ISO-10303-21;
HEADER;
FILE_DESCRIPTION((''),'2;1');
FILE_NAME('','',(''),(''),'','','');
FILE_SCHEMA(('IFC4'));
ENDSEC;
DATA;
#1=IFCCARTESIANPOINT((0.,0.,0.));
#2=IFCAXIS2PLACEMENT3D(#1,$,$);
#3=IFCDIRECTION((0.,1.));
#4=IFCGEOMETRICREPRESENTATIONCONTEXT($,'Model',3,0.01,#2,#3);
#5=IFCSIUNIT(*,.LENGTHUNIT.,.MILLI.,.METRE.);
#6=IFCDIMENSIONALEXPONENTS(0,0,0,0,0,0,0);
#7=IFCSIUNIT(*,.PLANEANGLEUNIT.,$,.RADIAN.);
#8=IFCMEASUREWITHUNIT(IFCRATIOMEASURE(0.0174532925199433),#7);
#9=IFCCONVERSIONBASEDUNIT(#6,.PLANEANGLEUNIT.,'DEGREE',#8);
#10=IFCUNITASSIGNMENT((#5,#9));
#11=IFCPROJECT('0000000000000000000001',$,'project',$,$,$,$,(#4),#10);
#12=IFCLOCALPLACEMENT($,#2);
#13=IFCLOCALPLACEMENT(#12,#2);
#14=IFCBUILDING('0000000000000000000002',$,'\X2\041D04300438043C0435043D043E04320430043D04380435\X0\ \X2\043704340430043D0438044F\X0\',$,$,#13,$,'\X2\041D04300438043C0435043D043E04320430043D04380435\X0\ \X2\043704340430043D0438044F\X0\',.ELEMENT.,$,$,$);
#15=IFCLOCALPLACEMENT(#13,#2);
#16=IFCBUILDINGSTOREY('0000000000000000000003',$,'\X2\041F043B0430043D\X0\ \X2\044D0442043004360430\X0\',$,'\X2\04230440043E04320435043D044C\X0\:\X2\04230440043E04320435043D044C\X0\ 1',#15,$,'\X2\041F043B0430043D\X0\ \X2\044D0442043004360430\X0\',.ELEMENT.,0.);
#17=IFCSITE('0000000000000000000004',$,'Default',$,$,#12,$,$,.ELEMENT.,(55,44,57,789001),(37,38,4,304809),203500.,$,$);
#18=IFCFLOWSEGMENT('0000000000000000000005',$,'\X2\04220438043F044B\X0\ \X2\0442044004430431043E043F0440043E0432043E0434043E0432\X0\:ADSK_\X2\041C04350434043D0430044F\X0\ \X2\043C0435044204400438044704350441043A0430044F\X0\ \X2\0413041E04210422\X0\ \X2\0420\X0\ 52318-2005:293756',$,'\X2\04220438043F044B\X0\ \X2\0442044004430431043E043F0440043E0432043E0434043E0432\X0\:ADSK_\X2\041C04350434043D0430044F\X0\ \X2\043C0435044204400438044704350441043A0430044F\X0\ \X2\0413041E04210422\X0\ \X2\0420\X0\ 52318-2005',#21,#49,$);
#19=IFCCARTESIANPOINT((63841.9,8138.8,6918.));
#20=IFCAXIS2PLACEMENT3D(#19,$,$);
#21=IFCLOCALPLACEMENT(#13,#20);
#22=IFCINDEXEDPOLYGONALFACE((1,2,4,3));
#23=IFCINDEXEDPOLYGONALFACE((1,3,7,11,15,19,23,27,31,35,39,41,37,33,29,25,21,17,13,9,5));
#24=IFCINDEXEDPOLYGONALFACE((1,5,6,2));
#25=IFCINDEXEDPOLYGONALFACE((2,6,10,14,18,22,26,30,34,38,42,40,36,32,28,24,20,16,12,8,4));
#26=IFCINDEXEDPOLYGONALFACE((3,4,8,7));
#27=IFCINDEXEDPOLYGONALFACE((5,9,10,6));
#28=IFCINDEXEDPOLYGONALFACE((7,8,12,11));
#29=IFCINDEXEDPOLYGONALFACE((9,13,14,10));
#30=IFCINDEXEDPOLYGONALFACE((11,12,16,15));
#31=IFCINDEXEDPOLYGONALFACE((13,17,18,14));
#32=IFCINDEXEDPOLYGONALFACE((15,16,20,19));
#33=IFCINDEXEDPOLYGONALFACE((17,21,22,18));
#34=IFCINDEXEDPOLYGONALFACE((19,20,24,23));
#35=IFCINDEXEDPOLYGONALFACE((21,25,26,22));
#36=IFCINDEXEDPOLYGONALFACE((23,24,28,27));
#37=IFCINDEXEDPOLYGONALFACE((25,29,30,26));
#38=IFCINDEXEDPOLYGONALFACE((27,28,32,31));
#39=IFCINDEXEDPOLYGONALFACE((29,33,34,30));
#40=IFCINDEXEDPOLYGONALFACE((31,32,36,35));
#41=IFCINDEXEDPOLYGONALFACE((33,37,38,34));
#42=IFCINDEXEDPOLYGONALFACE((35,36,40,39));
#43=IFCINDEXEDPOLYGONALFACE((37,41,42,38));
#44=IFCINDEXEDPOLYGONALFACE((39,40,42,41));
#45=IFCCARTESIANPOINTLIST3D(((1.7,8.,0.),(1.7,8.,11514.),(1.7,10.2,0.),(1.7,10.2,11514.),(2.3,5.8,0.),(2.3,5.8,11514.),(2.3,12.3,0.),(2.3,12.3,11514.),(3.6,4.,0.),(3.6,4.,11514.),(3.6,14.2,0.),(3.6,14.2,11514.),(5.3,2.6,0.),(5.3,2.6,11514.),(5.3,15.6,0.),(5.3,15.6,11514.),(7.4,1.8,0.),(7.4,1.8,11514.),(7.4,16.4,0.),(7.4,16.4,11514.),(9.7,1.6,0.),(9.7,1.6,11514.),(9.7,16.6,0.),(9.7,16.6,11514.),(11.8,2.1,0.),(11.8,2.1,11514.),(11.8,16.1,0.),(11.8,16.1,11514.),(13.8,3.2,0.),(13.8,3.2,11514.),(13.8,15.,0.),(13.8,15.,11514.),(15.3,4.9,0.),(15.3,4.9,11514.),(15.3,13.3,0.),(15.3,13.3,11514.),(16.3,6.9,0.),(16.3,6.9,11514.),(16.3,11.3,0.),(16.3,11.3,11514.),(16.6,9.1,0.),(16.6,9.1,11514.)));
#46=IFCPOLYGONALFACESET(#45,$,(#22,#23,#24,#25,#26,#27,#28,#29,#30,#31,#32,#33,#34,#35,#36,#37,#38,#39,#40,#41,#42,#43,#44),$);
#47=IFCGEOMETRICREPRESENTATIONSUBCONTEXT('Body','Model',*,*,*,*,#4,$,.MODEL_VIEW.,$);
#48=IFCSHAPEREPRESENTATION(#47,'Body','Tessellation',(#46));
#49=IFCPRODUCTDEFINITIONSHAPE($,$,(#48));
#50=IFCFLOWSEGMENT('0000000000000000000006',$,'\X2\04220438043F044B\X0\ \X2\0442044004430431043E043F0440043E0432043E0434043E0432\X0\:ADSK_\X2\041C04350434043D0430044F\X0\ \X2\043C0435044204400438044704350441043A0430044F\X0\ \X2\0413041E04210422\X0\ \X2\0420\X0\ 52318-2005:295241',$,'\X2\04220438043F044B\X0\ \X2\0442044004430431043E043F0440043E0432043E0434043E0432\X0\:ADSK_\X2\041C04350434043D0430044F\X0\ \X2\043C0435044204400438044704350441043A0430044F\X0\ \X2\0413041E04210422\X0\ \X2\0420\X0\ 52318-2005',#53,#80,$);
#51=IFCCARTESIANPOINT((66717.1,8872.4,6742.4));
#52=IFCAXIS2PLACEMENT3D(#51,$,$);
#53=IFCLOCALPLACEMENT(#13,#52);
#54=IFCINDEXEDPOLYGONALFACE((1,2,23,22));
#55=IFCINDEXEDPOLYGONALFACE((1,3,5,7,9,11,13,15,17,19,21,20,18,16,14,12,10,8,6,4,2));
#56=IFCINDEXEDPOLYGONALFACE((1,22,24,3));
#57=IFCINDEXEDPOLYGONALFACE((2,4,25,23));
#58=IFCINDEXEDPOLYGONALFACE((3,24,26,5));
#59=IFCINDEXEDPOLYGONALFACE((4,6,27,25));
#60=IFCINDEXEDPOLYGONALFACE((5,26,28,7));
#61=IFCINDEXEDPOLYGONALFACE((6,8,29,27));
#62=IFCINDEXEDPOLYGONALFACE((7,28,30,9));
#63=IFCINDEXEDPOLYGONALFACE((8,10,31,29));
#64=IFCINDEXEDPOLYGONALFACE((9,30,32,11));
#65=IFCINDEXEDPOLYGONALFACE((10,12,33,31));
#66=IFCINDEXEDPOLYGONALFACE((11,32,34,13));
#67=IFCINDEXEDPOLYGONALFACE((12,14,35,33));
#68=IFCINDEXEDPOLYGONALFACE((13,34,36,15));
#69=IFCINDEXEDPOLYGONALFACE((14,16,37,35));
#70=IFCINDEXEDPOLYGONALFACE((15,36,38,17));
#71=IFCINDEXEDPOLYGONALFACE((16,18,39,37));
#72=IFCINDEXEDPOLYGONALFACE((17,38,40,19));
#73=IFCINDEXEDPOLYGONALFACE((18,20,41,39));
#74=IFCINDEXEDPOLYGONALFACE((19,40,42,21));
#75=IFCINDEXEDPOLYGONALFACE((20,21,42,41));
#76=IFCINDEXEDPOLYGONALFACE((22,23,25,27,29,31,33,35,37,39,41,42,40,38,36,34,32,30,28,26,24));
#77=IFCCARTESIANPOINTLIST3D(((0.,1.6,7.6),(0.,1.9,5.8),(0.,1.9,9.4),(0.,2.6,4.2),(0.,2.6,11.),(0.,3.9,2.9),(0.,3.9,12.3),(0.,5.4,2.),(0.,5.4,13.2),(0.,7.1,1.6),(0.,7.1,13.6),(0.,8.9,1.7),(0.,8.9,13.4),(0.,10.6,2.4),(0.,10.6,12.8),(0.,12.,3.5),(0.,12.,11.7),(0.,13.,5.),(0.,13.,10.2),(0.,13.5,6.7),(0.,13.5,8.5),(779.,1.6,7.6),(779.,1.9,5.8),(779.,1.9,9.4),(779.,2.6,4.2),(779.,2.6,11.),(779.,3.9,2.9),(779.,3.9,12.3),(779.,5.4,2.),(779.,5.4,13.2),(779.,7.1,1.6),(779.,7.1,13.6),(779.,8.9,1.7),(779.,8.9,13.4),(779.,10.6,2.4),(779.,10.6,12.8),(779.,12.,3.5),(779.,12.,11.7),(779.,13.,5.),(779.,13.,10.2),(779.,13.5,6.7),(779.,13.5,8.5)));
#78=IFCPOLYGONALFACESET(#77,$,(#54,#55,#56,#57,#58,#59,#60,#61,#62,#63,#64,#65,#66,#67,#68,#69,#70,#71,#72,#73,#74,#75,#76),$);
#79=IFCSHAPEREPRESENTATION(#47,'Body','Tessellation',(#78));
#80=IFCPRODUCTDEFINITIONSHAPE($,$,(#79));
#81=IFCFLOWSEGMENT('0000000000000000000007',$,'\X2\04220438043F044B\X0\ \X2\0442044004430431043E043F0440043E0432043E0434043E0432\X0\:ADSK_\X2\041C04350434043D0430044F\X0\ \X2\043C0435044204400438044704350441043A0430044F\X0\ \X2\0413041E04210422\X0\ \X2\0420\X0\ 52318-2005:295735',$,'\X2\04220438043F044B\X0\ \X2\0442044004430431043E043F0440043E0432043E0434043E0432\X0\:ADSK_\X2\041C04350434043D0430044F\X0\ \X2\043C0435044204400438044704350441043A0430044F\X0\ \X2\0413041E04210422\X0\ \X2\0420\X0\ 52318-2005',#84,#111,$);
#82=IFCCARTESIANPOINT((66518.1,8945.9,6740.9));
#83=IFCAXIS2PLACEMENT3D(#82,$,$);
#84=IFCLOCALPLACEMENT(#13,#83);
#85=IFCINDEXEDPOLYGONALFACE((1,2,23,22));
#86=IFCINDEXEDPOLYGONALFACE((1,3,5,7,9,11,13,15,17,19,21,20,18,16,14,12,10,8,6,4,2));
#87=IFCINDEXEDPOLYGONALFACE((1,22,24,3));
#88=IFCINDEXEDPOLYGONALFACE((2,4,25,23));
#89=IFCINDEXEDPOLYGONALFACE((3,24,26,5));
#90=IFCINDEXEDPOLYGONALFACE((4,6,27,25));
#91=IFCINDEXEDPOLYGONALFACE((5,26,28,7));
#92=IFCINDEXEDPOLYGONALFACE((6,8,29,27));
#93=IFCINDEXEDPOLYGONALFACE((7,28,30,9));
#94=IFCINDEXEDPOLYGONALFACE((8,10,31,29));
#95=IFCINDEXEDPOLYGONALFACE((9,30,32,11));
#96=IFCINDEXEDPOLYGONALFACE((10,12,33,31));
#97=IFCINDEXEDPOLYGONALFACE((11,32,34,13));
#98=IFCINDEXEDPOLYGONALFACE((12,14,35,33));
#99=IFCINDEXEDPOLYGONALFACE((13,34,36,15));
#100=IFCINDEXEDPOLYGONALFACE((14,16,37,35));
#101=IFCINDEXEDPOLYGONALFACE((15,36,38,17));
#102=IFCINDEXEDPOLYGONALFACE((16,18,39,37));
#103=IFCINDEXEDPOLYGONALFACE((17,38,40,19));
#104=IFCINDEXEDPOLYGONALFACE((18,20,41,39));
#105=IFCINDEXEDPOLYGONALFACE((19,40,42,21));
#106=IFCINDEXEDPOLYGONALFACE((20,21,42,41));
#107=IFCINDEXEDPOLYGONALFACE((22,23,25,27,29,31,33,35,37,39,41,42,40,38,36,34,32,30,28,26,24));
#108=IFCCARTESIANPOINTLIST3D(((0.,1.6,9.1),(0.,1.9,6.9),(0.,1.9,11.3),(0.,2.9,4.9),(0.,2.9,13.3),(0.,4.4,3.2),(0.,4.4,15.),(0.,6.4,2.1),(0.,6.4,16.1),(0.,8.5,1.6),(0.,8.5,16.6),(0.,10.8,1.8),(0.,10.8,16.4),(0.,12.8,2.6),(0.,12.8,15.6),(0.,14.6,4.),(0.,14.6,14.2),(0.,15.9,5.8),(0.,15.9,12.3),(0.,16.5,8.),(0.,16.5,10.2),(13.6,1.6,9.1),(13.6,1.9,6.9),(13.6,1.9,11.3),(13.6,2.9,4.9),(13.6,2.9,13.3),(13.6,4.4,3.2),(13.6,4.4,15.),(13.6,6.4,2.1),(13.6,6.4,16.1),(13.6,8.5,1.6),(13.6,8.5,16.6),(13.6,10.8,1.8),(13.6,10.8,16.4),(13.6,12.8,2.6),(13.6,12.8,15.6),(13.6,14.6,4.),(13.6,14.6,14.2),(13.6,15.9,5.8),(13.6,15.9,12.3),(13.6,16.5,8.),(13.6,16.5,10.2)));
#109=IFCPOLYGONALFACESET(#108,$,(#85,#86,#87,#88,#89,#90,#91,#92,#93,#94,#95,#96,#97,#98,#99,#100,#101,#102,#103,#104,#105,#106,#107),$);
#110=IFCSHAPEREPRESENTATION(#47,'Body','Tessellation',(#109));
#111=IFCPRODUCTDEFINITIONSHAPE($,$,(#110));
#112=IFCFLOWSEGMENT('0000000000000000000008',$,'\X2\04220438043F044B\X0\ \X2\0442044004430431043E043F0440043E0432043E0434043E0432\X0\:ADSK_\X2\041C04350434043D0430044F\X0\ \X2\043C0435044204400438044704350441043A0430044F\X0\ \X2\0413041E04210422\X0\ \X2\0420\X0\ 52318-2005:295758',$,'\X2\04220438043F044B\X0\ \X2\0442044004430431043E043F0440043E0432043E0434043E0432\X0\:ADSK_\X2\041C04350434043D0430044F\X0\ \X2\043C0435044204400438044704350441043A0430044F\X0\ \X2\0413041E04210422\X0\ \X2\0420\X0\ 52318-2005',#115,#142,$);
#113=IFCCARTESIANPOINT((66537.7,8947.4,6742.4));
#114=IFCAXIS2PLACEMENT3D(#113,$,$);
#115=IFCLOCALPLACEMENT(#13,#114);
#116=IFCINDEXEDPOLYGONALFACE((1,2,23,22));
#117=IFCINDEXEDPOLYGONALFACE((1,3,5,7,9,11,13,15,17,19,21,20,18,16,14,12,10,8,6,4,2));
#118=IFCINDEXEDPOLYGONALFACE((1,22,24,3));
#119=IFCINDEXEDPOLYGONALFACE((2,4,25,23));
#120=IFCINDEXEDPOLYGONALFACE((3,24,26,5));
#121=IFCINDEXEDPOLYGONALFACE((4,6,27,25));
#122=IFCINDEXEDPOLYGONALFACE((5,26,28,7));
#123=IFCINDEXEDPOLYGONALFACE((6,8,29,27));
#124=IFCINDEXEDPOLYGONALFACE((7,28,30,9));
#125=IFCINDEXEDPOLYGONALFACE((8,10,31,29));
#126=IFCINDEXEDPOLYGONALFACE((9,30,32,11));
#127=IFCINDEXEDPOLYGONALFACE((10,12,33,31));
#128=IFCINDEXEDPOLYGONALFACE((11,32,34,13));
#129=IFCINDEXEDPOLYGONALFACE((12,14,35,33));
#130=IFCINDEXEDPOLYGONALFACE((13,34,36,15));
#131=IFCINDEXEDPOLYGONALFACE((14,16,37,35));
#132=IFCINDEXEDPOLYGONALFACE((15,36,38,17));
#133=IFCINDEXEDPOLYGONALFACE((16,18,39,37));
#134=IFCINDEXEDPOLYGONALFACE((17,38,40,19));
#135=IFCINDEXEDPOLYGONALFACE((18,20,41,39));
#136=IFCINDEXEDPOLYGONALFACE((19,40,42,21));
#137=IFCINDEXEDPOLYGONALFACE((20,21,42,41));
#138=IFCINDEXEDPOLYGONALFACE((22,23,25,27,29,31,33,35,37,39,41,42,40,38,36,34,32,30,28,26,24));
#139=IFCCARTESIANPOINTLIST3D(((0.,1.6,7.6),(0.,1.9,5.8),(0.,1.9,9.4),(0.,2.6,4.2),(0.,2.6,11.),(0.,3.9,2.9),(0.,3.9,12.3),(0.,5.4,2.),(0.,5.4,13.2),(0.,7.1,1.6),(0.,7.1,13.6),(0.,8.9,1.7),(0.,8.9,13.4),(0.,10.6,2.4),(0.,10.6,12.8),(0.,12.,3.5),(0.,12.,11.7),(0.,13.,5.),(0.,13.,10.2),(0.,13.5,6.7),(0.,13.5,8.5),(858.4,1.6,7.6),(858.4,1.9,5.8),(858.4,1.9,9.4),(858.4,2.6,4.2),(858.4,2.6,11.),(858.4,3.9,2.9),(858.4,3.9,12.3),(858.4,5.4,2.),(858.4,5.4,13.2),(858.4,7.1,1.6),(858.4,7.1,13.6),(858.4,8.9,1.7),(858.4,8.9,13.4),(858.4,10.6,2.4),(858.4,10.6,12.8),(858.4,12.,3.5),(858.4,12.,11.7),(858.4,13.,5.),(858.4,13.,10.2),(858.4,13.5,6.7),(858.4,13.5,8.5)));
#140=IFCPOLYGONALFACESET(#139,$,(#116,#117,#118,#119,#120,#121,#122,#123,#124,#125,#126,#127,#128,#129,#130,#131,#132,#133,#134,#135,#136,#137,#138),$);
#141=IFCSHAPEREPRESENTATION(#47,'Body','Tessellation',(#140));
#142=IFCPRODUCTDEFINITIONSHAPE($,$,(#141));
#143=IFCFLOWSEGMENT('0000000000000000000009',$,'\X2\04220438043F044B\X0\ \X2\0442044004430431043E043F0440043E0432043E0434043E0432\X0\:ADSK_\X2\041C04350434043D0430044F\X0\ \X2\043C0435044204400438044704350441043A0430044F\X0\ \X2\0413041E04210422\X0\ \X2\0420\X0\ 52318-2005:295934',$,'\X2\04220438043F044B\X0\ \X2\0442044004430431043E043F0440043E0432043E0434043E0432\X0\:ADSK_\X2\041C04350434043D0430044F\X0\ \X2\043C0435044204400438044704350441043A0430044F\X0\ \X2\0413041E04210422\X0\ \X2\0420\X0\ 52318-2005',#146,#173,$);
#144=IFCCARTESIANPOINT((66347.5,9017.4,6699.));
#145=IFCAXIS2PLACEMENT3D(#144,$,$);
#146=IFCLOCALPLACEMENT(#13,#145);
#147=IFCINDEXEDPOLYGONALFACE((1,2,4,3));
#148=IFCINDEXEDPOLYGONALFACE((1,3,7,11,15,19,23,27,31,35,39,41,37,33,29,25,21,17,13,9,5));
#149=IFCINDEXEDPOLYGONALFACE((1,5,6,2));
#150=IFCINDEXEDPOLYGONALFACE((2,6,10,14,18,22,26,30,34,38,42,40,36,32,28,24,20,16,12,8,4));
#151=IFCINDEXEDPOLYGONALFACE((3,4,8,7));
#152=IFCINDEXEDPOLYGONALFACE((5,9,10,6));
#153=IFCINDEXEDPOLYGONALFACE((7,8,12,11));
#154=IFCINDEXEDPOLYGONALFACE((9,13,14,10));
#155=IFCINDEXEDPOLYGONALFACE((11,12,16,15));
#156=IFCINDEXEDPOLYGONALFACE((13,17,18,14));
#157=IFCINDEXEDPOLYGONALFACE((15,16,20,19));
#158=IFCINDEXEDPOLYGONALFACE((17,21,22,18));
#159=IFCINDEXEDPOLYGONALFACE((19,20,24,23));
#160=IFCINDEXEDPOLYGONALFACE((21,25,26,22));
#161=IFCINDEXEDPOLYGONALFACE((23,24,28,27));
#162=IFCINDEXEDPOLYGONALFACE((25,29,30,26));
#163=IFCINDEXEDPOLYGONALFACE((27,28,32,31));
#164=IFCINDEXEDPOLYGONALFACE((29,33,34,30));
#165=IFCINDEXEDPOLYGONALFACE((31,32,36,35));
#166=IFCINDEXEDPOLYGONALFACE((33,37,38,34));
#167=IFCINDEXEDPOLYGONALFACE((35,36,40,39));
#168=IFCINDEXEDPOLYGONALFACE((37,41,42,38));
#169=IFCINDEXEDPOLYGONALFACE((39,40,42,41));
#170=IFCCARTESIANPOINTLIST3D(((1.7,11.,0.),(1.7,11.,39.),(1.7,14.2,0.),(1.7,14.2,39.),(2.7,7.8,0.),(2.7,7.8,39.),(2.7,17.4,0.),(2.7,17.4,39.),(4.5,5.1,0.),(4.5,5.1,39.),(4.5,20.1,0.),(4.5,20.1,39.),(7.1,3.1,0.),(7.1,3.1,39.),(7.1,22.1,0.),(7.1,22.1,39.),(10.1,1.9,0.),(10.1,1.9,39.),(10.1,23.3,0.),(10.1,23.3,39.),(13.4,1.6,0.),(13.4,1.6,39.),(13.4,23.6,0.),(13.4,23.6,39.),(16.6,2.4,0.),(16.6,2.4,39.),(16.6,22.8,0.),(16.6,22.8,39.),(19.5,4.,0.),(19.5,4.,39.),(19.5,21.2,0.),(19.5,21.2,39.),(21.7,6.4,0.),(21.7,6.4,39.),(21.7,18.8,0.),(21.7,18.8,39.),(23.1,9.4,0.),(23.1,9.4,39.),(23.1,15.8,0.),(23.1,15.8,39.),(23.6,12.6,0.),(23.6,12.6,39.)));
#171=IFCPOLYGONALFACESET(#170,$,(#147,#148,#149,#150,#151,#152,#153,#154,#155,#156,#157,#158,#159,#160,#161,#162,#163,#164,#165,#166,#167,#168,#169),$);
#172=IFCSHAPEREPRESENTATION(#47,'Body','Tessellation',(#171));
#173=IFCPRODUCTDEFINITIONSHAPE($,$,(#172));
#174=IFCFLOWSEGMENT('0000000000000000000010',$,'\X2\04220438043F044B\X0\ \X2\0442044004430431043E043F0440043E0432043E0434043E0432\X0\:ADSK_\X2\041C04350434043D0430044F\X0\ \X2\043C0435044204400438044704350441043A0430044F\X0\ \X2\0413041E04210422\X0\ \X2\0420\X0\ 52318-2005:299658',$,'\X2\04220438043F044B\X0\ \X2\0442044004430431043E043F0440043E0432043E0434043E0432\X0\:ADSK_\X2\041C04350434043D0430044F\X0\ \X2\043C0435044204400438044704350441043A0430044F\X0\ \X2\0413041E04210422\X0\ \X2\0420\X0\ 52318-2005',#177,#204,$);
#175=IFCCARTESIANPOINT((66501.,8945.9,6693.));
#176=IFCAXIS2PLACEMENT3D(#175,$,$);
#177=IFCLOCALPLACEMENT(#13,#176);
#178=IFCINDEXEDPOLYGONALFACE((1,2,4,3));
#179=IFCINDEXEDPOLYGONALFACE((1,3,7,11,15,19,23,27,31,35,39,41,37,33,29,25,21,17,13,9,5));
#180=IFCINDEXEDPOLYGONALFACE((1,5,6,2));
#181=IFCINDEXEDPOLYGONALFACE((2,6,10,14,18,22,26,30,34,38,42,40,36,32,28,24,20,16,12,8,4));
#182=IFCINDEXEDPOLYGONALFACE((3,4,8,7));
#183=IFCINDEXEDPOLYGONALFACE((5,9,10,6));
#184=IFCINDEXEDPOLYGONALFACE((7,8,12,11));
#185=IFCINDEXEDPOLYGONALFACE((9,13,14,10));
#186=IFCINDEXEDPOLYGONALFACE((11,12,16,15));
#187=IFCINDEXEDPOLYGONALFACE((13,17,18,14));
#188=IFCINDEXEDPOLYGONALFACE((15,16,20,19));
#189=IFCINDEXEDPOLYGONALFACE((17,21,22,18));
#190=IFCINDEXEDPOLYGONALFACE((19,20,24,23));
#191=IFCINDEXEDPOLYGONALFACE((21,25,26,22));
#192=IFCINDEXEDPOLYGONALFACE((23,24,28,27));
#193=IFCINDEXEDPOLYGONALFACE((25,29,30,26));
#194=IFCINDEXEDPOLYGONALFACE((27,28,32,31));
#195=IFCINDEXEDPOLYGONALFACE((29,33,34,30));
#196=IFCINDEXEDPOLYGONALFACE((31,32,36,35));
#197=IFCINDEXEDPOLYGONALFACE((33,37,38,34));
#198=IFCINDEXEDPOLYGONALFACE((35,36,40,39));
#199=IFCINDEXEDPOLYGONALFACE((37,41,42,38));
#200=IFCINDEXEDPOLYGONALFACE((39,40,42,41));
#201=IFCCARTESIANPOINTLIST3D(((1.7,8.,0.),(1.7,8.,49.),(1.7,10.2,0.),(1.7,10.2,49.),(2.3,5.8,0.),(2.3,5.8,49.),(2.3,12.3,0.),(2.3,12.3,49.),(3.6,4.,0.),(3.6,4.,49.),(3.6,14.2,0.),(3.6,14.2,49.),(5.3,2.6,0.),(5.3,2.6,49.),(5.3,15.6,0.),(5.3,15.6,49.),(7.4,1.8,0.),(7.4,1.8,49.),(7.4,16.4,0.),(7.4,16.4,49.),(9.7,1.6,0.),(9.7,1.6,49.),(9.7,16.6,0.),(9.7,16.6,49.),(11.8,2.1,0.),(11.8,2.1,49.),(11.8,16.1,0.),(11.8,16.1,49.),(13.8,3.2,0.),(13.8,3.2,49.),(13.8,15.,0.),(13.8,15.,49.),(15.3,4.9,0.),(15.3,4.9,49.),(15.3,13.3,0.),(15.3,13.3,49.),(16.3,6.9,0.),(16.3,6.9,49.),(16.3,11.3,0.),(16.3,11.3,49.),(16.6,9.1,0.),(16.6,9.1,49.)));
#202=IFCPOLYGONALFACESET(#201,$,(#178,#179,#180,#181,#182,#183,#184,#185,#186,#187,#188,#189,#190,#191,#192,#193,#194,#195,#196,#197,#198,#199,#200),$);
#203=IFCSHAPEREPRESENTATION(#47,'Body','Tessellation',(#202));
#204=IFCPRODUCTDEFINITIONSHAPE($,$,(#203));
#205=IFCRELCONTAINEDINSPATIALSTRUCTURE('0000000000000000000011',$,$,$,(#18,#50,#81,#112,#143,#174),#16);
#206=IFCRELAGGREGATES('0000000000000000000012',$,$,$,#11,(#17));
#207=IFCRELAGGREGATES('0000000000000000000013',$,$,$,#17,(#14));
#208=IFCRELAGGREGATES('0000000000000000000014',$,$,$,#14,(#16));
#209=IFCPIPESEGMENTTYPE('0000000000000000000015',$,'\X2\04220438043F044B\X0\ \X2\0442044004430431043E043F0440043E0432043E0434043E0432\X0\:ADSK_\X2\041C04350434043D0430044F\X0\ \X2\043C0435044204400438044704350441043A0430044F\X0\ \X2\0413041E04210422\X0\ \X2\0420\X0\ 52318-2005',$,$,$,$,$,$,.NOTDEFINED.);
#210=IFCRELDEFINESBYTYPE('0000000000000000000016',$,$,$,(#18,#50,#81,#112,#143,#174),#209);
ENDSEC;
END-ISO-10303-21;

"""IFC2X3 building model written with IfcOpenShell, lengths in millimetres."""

from ifc_helpers import new_model, entity, si_unit, converted_unit, direction, frame, frame_2d, origin, origin_2d_with_axis, place, context, subcontext, project, spatial, circle, extrude, type_object, element, save


model = new_model("IFC2X3")

# Units and contexts
model_context = context("Model", 3, precision=0.01, world=origin(), true_north=direction((0.0, 1.0)))
body_context = subcontext(model_context, "Body", "Model", "MODEL_VIEW")
ifc_project = project(units=[si_unit("LENGTHUNIT", "METRE", prefix="MILLI"), converted_unit("PLANEANGLEUNIT", "DEGREE", entity("IfcRatioMeasure", 0.0174532925199433), si_unit("PLANEANGLEUNIT", "RADIAN"), dimensions=[0, 0, 0, 0, 0, 0, 0])], contexts=[model_context])

# Site, building, storey
site_placement = place(None, frame((0.0, 0.0, 0.0)))
site = spatial("IfcSite", under=ifc_project, at=site_placement, Name="Default", CompositionType="ELEMENT", RefLatitude=(55, 44, 57, 789001), RefLongitude=(37, 38, 4, 304809), RefElevation=203500.0)
building_placement = place(site_placement, origin())
building = spatial("IfcBuilding", under=site, at=building_placement, Name="Наименование здания", LongName="Наименование здания", CompositionType="ELEMENT")
storey_placement = place(building_placement, origin())
storey = spatial("IfcBuildingStorey", under=building, at=storey_placement, Name="План этажа", ObjectType="Уровень:Уровень 1", LongName="План этажа", CompositionType="ELEMENT", Elevation=0.0)

# Flow segments
pipe_segment_type = type_object("IfcPipeSegmentType", Name="Типы трубопроводов:ADSK_Медная метрическая ГОСТ Р 52318-2005", PredefinedType="NOTDEFINED")
flow_segment_1_placement = place(building_placement, frame((63841.9, 8138.8, 6918.0)))
element("IfcFlowSegment", 1, at=flow_segment_1_placement, inside=storey, type_object=pipe_segment_type, Name="Типы трубопроводов:ADSK_Медная метрическая ГОСТ Р 52318-2005:293756", ObjectType="Типы трубопроводов:ADSK_Медная метрическая ГОСТ Р 52318-2005", context=body_context, shape_type="SweptSolid", body=[
    extrude(circle(Radius=7.5, at=frame_2d((0.0, 0.0), x_axis=(1.0, 0.0))), frame((9.1, 9.1, 0.0)), (0.0, 0.0, 1.0), 11514.0),
])
flow_segment_2_placement = place(building_placement, frame((66717.1, 8872.4, 6742.4)))
element("IfcFlowSegment", 2, at=flow_segment_2_placement, inside=storey, type_object=pipe_segment_type, Name="Типы трубопроводов:ADSK_Медная метрическая ГОСТ Р 52318-2005:295241", ObjectType="Типы трубопроводов:ADSK_Медная метрическая ГОСТ Р 52318-2005", context=body_context, shape_type="SweptSolid", body=[
    extrude(circle(Radius=6.0, at=frame_2d((0.0, 0.0), x_axis=(1.0, 0.0))), frame((0.0, 7.6, 7.6), z_axis=(1.0, 0.0, 0.0), x_axis=(0.0, -1.0, 0.0)), (0.0, 0.0, 1.0), 779.0),
])
flow_segment_3_placement = place(building_placement, frame((66518.1, 8945.9, 6740.9)))
element("IfcFlowSegment", 3, at=flow_segment_3_placement, inside=storey, type_object=pipe_segment_type, Name="Типы трубопроводов:ADSK_Медная метрическая ГОСТ Р 52318-2005:295735", ObjectType="Типы трубопроводов:ADSK_Медная метрическая ГОСТ Р 52318-2005", context=body_context, shape_type="SweptSolid", body=[
    extrude(circle(Radius=7.5, at=origin_2d_with_axis()), frame((0.0, 9.1, 9.1), z_axis=(1.0, 0.0, 0.0), x_axis=(0.0, -1.0, 0.0)), (0.0, 0.0, 1.0), 13.6),
])
flow_segment_4_placement = place(building_placement, frame((66537.7, 8947.4, 6742.4)))
element("IfcFlowSegment", 4, at=flow_segment_4_placement, inside=storey, type_object=pipe_segment_type, Name="Типы трубопроводов:ADSK_Медная метрическая ГОСТ Р 52318-2005:295758", ObjectType="Типы трубопроводов:ADSK_Медная метрическая ГОСТ Р 52318-2005", context=body_context, shape_type="SweptSolid", body=[
    extrude(circle(Radius=6.0, at=frame_2d((0.0, 0.0), x_axis=(1.0, 0.0))), frame((0.0, 7.6, 7.6), z_axis=(1.0, 0.0, 0.0), x_axis=(0.0, -1.0, 0.0)), (0.0, 0.0, 1.0), 858.4),
])
flow_segment_5_placement = place(building_placement, frame((66347.5, 9017.4, 6699.0)))
element("IfcFlowSegment", 5, at=flow_segment_5_placement, inside=storey, type_object=pipe_segment_type, Name="Типы трубопроводов:ADSK_Медная метрическая ГОСТ Р 52318-2005:295934", ObjectType="Типы трубопроводов:ADSK_Медная метрическая ГОСТ Р 52318-2005", context=body_context, shape_type="SweptSolid", body=[
    extrude(circle(Radius=11.0, at=origin_2d_with_axis()), frame((12.6, 12.6, 0.0)), (0.0, 0.0, 1.0), 39.0),
])
flow_segment_6_placement = place(building_placement, frame((66501.0, 8945.9, 6693.0)))
element("IfcFlowSegment", 6, at=flow_segment_6_placement, inside=storey, type_object=pipe_segment_type, Name="Типы трубопроводов:ADSK_Медная метрическая ГОСТ Р 52318-2005:299658", ObjectType="Типы трубопроводов:ADSK_Медная метрическая ГОСТ Р 52318-2005", context=body_context, shape_type="SweptSolid", body=[
    extrude(circle(Radius=7.5, at=origin_2d_with_axis()), frame((9.1, 9.1, 0.0)), (0.0, 0.0, 1.0), 49.0),
])

save(model, "model.ifc")
